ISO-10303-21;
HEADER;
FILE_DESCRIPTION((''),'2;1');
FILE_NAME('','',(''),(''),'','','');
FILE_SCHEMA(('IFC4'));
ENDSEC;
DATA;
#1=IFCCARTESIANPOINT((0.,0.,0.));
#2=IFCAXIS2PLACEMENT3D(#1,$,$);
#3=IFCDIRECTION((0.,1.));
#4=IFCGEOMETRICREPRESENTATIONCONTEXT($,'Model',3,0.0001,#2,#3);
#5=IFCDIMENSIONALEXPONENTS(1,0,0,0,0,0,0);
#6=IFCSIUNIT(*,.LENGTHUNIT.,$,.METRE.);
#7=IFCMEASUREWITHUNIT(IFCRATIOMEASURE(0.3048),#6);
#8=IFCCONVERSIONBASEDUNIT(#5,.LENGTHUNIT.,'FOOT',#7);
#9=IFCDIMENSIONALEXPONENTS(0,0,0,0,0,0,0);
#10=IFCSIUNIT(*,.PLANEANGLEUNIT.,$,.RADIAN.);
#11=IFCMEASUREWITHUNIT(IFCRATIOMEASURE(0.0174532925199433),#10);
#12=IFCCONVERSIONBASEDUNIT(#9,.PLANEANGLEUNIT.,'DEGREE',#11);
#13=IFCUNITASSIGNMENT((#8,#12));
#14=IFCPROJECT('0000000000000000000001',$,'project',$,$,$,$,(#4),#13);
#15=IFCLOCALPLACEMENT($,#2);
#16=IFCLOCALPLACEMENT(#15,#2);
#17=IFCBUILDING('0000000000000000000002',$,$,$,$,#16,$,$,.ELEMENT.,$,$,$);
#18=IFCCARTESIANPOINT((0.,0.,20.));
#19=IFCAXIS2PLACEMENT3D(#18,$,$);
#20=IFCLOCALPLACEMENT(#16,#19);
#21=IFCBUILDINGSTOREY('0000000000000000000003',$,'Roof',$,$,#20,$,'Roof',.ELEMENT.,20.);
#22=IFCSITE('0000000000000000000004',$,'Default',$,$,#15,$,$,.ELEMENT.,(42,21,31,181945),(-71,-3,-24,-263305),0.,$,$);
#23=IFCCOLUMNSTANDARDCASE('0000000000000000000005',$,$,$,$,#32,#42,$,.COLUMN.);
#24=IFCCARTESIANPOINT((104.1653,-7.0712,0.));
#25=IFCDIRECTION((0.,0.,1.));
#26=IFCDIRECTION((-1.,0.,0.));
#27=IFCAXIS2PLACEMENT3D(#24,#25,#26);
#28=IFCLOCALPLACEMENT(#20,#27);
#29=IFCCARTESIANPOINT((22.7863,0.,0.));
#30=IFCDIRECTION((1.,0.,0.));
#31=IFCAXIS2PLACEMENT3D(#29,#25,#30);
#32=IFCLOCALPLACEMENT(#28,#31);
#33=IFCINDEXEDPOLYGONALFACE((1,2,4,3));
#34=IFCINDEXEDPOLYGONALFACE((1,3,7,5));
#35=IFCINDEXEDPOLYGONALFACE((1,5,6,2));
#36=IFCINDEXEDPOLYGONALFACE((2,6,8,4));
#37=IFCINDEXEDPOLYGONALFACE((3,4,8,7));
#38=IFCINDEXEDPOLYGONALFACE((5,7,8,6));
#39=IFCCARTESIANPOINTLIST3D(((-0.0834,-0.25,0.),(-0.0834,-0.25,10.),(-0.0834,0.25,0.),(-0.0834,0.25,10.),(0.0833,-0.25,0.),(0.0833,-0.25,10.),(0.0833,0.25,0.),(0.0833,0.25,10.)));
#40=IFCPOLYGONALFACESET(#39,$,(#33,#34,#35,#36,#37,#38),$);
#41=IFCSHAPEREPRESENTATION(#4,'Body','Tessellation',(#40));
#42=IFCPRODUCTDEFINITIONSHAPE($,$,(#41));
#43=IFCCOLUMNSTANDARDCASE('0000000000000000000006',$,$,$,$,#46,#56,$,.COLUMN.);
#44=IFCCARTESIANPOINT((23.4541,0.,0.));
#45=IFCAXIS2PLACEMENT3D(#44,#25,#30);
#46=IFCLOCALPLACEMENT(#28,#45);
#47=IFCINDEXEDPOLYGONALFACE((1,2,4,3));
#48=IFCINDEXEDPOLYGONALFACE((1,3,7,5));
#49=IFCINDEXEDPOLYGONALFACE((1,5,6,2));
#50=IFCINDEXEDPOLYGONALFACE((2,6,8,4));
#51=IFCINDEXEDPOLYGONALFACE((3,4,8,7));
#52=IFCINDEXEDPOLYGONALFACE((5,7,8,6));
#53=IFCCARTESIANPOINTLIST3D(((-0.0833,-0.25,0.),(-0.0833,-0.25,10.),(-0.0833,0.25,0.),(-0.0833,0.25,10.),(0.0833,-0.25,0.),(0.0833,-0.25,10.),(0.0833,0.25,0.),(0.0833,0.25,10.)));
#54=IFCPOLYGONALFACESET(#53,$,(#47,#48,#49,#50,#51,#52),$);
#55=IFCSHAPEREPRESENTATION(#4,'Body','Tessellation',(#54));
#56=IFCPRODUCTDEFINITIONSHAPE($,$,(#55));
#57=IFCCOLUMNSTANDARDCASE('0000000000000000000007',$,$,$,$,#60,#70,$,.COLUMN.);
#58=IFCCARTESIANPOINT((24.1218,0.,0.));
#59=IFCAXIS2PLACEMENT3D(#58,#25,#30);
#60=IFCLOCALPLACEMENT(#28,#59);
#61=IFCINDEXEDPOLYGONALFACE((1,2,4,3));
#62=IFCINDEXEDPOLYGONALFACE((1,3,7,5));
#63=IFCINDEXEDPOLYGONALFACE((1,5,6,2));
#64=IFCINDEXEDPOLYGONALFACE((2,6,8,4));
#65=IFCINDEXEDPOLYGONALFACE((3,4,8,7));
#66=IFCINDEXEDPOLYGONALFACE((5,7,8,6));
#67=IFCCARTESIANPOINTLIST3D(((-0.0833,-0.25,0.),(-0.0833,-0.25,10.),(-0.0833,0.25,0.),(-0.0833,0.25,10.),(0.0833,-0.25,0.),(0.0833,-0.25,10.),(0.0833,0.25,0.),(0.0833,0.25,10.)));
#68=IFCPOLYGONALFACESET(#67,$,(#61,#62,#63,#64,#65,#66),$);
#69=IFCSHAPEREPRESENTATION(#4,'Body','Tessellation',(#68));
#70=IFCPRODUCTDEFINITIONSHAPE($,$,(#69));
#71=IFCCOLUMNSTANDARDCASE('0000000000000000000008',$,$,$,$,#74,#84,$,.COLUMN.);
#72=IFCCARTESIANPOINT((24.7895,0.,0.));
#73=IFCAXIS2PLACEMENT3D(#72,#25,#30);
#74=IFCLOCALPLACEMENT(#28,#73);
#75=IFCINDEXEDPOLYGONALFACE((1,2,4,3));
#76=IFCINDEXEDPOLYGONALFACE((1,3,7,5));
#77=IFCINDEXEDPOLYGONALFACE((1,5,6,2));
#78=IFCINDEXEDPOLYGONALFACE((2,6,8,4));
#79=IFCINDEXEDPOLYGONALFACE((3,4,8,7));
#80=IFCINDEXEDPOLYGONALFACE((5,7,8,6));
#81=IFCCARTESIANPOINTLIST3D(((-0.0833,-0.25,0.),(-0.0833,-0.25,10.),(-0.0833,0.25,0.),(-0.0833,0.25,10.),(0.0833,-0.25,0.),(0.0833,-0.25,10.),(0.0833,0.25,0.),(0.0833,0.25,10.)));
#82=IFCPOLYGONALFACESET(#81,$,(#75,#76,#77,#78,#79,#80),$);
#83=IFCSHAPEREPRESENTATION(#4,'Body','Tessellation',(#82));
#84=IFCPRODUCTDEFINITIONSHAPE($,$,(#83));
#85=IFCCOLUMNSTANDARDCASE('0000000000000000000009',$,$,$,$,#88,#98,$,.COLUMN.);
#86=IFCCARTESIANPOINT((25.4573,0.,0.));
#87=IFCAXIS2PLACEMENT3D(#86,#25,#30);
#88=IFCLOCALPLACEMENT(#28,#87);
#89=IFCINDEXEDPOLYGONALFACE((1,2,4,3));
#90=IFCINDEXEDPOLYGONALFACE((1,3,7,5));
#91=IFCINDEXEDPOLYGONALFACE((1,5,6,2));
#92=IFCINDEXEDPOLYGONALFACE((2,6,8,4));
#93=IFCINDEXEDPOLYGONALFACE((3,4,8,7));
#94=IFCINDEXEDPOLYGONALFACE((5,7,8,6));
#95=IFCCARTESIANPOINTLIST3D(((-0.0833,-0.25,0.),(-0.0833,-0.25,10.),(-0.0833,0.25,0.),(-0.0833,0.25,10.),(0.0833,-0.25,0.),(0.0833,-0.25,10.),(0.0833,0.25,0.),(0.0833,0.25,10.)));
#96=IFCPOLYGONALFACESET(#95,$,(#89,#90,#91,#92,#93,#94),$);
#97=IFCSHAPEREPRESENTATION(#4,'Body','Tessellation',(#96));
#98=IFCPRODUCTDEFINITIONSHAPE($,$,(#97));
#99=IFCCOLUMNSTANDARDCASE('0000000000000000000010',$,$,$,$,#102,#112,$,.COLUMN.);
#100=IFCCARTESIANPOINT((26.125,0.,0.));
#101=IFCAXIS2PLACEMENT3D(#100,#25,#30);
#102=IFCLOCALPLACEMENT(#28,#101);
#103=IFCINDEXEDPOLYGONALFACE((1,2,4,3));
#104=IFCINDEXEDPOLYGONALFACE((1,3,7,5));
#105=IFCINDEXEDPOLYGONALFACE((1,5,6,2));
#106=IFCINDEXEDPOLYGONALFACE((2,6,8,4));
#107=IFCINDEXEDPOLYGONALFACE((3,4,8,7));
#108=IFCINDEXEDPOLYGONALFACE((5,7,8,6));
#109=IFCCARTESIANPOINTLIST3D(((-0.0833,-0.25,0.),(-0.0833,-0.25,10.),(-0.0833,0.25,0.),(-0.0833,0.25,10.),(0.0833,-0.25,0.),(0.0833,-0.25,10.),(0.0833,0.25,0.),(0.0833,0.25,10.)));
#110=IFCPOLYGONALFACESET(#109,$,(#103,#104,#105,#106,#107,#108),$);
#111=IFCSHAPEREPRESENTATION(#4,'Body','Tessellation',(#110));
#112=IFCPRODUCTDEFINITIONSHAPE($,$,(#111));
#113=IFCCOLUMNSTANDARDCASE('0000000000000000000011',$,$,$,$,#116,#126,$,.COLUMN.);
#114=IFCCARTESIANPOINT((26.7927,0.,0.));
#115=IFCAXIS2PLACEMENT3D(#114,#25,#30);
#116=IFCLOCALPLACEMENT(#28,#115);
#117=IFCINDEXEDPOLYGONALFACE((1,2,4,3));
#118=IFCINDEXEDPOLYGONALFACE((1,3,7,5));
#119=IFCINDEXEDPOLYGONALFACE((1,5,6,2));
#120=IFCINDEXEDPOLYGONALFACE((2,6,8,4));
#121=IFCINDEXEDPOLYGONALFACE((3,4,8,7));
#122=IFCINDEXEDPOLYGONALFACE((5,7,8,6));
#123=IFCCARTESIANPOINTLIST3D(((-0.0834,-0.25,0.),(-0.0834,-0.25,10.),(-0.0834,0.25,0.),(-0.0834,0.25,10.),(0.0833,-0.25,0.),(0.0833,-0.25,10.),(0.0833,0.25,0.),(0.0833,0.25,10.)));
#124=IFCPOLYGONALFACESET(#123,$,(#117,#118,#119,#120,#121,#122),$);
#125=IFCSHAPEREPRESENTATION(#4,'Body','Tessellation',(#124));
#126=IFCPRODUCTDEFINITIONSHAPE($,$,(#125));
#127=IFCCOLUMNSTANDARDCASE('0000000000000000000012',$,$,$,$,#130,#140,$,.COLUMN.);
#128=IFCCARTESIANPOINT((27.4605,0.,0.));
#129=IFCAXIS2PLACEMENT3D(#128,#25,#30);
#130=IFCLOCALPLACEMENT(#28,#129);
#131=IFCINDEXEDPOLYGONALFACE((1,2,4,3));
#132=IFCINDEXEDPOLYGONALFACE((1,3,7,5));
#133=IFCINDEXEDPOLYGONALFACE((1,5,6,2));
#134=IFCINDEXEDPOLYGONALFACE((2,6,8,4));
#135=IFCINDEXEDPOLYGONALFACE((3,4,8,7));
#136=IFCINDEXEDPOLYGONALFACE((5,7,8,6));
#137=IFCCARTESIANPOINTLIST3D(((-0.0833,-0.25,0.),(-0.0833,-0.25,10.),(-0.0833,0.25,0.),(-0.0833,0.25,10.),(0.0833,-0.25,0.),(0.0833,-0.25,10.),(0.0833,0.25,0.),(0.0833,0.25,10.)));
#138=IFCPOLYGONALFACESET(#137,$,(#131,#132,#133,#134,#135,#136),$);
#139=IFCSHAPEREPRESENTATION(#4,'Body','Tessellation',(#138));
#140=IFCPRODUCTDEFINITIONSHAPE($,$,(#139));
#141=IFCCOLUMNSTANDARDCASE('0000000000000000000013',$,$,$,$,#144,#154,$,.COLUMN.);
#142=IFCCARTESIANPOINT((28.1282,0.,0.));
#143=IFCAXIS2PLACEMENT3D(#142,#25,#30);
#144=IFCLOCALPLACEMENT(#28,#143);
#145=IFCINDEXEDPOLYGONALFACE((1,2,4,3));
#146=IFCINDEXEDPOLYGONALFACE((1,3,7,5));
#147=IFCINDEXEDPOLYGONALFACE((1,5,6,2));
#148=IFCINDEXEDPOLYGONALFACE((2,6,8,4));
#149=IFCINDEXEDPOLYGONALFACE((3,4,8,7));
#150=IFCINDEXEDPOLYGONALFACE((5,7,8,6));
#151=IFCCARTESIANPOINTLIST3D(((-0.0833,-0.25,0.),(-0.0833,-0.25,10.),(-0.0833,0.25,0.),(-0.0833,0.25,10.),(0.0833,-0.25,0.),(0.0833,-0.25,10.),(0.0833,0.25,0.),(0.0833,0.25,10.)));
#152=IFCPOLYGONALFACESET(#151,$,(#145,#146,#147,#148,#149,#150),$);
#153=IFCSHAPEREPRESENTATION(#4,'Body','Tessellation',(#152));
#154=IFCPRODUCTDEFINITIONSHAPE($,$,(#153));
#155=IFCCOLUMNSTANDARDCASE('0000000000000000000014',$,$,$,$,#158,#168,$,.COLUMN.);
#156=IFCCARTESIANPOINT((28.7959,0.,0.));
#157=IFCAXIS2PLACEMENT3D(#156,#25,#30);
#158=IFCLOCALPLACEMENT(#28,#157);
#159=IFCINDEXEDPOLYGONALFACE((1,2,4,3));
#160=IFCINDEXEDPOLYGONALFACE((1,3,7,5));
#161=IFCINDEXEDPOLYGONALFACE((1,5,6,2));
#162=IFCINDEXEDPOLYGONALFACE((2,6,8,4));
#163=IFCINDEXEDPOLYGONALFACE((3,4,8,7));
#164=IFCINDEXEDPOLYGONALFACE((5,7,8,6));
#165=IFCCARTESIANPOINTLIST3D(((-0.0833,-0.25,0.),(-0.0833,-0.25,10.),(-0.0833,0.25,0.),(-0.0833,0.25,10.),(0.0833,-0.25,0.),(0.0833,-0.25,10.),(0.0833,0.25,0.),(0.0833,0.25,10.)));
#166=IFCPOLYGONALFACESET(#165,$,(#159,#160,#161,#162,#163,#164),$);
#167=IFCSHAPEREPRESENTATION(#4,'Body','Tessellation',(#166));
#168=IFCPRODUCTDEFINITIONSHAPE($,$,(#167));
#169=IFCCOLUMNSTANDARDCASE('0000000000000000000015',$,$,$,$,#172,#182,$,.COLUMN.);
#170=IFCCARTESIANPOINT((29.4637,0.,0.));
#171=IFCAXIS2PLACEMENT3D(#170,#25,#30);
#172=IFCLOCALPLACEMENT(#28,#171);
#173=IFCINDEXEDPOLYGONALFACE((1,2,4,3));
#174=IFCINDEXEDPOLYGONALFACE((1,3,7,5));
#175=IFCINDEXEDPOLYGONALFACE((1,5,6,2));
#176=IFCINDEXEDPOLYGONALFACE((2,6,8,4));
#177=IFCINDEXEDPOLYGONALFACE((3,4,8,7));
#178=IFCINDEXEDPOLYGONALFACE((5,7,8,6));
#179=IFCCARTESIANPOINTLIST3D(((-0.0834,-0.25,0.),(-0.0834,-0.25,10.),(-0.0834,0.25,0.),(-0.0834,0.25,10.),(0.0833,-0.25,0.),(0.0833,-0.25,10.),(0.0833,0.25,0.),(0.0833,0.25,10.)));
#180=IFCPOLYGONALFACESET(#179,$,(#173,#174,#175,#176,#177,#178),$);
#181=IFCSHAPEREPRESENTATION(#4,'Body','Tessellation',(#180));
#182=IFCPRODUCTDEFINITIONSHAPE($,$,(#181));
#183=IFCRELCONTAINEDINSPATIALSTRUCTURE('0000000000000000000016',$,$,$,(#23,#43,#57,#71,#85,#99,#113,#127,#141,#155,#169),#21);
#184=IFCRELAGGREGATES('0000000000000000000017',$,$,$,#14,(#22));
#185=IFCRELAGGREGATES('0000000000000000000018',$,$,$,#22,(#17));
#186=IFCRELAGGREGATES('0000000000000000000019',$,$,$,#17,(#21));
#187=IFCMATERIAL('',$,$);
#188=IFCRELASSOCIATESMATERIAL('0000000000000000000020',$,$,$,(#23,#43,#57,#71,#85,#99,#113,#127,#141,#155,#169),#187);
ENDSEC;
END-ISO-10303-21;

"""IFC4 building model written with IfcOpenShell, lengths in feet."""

from ifc_helpers import new_model, entity, si_unit, converted_unit, direction, frame, origin, place, context, project, spatial, rectangle, extrude, material, element, save


model = new_model("IFC4")

# Units and contexts
model_context = context("Model", 3, precision=0.0001, world=origin(), true_north=direction((0.0, 1.0)))
ifc_project = project(units=[converted_unit("LENGTHUNIT", "FOOT", entity("IfcRatioMeasure", 0.3048), si_unit("LENGTHUNIT", "METRE"), dimensions=[1, 0, 0, 0, 0, 0, 0]), converted_unit("PLANEANGLEUNIT", "DEGREE", entity("IfcRatioMeasure", 0.0174532925199433), si_unit("PLANEANGLEUNIT", "RADIAN"), dimensions=[0, 0, 0, 0, 0, 0, 0])], contexts=[model_context])

# Site, building, storey
site_placement = place(None, origin())
site = spatial("IfcSite", under=ifc_project, at=site_placement, Name="Default", CompositionType="ELEMENT", RefLatitude=(42, 21, 31, 181945), RefLongitude=(-71, -3, -24, -263305), RefElevation=0.0)
building_placement = place(site_placement, origin())
building = spatial("IfcBuilding", under=site, at=building_placement, CompositionType="ELEMENT")
storey_placement = place(building_placement, frame((0.0, 0.0, 20.0)))
storey = spatial("IfcBuildingStorey", under=building, at=storey_placement, Name="Roof", LongName="Roof", CompositionType="ELEMENT", Elevation=20.0)

# Columns
ifc_material = material(Name="")
placement = place(storey_placement, frame((104.1653, -7.0712, 0.0), z_axis=(0.0, 0.0, 1.0), x_axis=(-1.0, 0.0, 0.0)))
for number, where, z_axis, x_axis in (
    (1, (22.7863, 0.0, 0.0), (0.0, 0.0, 1.0), (1.0, 0.0, 0.0)),
    (2, (23.4541, 0.0, 0.0), (0.0, 0.0, 1.0), (1.0, 0.0, 0.0)),
    (3, (24.1218, 0.0, 0.0), (0.0, 0.0, 1.0), (1.0, 0.0, 0.0)),
    (4, (24.7895, 0.0, 0.0), (0.0, 0.0, 1.0), (1.0, 0.0, 0.0)),
    (5, (25.4573, 0.0, 0.0), (0.0, 0.0, 1.0), (1.0, 0.0, 0.0)),
    (6, (26.125, 0.0, 0.0), (0.0, 0.0, 1.0), (1.0, 0.0, 0.0)),
    (7, (26.7927, 0.0, 0.0), (0.0, 0.0, 1.0), (1.0, 0.0, 0.0)),
    (8, (27.4605, 0.0, 0.0), (0.0, 0.0, 1.0), (1.0, 0.0, 0.0)),
    (9, (28.1282, 0.0, 0.0), (0.0, 0.0, 1.0), (1.0, 0.0, 0.0)),
    (10, (28.7959, 0.0, 0.0), (0.0, 0.0, 1.0), (1.0, 0.0, 0.0)),
    (11, (29.4637, 0.0, 0.0), (0.0, 0.0, 1.0), (1.0, 0.0, 0.0)),
):
    element("IfcColumnStandardCase", number, at=place(placement, frame(where, z_axis=z_axis, x_axis=x_axis)), inside=storey, material=ifc_material, PredefinedType="COLUMN", context=model_context, shape_type="SweptSolid", body=[
        extrude(rectangle(XDim=0.1667, YDim=0.5), origin(), (0.0, 0.0, 1.0), 10.0),
    ])

save(model, "model.ifc")
